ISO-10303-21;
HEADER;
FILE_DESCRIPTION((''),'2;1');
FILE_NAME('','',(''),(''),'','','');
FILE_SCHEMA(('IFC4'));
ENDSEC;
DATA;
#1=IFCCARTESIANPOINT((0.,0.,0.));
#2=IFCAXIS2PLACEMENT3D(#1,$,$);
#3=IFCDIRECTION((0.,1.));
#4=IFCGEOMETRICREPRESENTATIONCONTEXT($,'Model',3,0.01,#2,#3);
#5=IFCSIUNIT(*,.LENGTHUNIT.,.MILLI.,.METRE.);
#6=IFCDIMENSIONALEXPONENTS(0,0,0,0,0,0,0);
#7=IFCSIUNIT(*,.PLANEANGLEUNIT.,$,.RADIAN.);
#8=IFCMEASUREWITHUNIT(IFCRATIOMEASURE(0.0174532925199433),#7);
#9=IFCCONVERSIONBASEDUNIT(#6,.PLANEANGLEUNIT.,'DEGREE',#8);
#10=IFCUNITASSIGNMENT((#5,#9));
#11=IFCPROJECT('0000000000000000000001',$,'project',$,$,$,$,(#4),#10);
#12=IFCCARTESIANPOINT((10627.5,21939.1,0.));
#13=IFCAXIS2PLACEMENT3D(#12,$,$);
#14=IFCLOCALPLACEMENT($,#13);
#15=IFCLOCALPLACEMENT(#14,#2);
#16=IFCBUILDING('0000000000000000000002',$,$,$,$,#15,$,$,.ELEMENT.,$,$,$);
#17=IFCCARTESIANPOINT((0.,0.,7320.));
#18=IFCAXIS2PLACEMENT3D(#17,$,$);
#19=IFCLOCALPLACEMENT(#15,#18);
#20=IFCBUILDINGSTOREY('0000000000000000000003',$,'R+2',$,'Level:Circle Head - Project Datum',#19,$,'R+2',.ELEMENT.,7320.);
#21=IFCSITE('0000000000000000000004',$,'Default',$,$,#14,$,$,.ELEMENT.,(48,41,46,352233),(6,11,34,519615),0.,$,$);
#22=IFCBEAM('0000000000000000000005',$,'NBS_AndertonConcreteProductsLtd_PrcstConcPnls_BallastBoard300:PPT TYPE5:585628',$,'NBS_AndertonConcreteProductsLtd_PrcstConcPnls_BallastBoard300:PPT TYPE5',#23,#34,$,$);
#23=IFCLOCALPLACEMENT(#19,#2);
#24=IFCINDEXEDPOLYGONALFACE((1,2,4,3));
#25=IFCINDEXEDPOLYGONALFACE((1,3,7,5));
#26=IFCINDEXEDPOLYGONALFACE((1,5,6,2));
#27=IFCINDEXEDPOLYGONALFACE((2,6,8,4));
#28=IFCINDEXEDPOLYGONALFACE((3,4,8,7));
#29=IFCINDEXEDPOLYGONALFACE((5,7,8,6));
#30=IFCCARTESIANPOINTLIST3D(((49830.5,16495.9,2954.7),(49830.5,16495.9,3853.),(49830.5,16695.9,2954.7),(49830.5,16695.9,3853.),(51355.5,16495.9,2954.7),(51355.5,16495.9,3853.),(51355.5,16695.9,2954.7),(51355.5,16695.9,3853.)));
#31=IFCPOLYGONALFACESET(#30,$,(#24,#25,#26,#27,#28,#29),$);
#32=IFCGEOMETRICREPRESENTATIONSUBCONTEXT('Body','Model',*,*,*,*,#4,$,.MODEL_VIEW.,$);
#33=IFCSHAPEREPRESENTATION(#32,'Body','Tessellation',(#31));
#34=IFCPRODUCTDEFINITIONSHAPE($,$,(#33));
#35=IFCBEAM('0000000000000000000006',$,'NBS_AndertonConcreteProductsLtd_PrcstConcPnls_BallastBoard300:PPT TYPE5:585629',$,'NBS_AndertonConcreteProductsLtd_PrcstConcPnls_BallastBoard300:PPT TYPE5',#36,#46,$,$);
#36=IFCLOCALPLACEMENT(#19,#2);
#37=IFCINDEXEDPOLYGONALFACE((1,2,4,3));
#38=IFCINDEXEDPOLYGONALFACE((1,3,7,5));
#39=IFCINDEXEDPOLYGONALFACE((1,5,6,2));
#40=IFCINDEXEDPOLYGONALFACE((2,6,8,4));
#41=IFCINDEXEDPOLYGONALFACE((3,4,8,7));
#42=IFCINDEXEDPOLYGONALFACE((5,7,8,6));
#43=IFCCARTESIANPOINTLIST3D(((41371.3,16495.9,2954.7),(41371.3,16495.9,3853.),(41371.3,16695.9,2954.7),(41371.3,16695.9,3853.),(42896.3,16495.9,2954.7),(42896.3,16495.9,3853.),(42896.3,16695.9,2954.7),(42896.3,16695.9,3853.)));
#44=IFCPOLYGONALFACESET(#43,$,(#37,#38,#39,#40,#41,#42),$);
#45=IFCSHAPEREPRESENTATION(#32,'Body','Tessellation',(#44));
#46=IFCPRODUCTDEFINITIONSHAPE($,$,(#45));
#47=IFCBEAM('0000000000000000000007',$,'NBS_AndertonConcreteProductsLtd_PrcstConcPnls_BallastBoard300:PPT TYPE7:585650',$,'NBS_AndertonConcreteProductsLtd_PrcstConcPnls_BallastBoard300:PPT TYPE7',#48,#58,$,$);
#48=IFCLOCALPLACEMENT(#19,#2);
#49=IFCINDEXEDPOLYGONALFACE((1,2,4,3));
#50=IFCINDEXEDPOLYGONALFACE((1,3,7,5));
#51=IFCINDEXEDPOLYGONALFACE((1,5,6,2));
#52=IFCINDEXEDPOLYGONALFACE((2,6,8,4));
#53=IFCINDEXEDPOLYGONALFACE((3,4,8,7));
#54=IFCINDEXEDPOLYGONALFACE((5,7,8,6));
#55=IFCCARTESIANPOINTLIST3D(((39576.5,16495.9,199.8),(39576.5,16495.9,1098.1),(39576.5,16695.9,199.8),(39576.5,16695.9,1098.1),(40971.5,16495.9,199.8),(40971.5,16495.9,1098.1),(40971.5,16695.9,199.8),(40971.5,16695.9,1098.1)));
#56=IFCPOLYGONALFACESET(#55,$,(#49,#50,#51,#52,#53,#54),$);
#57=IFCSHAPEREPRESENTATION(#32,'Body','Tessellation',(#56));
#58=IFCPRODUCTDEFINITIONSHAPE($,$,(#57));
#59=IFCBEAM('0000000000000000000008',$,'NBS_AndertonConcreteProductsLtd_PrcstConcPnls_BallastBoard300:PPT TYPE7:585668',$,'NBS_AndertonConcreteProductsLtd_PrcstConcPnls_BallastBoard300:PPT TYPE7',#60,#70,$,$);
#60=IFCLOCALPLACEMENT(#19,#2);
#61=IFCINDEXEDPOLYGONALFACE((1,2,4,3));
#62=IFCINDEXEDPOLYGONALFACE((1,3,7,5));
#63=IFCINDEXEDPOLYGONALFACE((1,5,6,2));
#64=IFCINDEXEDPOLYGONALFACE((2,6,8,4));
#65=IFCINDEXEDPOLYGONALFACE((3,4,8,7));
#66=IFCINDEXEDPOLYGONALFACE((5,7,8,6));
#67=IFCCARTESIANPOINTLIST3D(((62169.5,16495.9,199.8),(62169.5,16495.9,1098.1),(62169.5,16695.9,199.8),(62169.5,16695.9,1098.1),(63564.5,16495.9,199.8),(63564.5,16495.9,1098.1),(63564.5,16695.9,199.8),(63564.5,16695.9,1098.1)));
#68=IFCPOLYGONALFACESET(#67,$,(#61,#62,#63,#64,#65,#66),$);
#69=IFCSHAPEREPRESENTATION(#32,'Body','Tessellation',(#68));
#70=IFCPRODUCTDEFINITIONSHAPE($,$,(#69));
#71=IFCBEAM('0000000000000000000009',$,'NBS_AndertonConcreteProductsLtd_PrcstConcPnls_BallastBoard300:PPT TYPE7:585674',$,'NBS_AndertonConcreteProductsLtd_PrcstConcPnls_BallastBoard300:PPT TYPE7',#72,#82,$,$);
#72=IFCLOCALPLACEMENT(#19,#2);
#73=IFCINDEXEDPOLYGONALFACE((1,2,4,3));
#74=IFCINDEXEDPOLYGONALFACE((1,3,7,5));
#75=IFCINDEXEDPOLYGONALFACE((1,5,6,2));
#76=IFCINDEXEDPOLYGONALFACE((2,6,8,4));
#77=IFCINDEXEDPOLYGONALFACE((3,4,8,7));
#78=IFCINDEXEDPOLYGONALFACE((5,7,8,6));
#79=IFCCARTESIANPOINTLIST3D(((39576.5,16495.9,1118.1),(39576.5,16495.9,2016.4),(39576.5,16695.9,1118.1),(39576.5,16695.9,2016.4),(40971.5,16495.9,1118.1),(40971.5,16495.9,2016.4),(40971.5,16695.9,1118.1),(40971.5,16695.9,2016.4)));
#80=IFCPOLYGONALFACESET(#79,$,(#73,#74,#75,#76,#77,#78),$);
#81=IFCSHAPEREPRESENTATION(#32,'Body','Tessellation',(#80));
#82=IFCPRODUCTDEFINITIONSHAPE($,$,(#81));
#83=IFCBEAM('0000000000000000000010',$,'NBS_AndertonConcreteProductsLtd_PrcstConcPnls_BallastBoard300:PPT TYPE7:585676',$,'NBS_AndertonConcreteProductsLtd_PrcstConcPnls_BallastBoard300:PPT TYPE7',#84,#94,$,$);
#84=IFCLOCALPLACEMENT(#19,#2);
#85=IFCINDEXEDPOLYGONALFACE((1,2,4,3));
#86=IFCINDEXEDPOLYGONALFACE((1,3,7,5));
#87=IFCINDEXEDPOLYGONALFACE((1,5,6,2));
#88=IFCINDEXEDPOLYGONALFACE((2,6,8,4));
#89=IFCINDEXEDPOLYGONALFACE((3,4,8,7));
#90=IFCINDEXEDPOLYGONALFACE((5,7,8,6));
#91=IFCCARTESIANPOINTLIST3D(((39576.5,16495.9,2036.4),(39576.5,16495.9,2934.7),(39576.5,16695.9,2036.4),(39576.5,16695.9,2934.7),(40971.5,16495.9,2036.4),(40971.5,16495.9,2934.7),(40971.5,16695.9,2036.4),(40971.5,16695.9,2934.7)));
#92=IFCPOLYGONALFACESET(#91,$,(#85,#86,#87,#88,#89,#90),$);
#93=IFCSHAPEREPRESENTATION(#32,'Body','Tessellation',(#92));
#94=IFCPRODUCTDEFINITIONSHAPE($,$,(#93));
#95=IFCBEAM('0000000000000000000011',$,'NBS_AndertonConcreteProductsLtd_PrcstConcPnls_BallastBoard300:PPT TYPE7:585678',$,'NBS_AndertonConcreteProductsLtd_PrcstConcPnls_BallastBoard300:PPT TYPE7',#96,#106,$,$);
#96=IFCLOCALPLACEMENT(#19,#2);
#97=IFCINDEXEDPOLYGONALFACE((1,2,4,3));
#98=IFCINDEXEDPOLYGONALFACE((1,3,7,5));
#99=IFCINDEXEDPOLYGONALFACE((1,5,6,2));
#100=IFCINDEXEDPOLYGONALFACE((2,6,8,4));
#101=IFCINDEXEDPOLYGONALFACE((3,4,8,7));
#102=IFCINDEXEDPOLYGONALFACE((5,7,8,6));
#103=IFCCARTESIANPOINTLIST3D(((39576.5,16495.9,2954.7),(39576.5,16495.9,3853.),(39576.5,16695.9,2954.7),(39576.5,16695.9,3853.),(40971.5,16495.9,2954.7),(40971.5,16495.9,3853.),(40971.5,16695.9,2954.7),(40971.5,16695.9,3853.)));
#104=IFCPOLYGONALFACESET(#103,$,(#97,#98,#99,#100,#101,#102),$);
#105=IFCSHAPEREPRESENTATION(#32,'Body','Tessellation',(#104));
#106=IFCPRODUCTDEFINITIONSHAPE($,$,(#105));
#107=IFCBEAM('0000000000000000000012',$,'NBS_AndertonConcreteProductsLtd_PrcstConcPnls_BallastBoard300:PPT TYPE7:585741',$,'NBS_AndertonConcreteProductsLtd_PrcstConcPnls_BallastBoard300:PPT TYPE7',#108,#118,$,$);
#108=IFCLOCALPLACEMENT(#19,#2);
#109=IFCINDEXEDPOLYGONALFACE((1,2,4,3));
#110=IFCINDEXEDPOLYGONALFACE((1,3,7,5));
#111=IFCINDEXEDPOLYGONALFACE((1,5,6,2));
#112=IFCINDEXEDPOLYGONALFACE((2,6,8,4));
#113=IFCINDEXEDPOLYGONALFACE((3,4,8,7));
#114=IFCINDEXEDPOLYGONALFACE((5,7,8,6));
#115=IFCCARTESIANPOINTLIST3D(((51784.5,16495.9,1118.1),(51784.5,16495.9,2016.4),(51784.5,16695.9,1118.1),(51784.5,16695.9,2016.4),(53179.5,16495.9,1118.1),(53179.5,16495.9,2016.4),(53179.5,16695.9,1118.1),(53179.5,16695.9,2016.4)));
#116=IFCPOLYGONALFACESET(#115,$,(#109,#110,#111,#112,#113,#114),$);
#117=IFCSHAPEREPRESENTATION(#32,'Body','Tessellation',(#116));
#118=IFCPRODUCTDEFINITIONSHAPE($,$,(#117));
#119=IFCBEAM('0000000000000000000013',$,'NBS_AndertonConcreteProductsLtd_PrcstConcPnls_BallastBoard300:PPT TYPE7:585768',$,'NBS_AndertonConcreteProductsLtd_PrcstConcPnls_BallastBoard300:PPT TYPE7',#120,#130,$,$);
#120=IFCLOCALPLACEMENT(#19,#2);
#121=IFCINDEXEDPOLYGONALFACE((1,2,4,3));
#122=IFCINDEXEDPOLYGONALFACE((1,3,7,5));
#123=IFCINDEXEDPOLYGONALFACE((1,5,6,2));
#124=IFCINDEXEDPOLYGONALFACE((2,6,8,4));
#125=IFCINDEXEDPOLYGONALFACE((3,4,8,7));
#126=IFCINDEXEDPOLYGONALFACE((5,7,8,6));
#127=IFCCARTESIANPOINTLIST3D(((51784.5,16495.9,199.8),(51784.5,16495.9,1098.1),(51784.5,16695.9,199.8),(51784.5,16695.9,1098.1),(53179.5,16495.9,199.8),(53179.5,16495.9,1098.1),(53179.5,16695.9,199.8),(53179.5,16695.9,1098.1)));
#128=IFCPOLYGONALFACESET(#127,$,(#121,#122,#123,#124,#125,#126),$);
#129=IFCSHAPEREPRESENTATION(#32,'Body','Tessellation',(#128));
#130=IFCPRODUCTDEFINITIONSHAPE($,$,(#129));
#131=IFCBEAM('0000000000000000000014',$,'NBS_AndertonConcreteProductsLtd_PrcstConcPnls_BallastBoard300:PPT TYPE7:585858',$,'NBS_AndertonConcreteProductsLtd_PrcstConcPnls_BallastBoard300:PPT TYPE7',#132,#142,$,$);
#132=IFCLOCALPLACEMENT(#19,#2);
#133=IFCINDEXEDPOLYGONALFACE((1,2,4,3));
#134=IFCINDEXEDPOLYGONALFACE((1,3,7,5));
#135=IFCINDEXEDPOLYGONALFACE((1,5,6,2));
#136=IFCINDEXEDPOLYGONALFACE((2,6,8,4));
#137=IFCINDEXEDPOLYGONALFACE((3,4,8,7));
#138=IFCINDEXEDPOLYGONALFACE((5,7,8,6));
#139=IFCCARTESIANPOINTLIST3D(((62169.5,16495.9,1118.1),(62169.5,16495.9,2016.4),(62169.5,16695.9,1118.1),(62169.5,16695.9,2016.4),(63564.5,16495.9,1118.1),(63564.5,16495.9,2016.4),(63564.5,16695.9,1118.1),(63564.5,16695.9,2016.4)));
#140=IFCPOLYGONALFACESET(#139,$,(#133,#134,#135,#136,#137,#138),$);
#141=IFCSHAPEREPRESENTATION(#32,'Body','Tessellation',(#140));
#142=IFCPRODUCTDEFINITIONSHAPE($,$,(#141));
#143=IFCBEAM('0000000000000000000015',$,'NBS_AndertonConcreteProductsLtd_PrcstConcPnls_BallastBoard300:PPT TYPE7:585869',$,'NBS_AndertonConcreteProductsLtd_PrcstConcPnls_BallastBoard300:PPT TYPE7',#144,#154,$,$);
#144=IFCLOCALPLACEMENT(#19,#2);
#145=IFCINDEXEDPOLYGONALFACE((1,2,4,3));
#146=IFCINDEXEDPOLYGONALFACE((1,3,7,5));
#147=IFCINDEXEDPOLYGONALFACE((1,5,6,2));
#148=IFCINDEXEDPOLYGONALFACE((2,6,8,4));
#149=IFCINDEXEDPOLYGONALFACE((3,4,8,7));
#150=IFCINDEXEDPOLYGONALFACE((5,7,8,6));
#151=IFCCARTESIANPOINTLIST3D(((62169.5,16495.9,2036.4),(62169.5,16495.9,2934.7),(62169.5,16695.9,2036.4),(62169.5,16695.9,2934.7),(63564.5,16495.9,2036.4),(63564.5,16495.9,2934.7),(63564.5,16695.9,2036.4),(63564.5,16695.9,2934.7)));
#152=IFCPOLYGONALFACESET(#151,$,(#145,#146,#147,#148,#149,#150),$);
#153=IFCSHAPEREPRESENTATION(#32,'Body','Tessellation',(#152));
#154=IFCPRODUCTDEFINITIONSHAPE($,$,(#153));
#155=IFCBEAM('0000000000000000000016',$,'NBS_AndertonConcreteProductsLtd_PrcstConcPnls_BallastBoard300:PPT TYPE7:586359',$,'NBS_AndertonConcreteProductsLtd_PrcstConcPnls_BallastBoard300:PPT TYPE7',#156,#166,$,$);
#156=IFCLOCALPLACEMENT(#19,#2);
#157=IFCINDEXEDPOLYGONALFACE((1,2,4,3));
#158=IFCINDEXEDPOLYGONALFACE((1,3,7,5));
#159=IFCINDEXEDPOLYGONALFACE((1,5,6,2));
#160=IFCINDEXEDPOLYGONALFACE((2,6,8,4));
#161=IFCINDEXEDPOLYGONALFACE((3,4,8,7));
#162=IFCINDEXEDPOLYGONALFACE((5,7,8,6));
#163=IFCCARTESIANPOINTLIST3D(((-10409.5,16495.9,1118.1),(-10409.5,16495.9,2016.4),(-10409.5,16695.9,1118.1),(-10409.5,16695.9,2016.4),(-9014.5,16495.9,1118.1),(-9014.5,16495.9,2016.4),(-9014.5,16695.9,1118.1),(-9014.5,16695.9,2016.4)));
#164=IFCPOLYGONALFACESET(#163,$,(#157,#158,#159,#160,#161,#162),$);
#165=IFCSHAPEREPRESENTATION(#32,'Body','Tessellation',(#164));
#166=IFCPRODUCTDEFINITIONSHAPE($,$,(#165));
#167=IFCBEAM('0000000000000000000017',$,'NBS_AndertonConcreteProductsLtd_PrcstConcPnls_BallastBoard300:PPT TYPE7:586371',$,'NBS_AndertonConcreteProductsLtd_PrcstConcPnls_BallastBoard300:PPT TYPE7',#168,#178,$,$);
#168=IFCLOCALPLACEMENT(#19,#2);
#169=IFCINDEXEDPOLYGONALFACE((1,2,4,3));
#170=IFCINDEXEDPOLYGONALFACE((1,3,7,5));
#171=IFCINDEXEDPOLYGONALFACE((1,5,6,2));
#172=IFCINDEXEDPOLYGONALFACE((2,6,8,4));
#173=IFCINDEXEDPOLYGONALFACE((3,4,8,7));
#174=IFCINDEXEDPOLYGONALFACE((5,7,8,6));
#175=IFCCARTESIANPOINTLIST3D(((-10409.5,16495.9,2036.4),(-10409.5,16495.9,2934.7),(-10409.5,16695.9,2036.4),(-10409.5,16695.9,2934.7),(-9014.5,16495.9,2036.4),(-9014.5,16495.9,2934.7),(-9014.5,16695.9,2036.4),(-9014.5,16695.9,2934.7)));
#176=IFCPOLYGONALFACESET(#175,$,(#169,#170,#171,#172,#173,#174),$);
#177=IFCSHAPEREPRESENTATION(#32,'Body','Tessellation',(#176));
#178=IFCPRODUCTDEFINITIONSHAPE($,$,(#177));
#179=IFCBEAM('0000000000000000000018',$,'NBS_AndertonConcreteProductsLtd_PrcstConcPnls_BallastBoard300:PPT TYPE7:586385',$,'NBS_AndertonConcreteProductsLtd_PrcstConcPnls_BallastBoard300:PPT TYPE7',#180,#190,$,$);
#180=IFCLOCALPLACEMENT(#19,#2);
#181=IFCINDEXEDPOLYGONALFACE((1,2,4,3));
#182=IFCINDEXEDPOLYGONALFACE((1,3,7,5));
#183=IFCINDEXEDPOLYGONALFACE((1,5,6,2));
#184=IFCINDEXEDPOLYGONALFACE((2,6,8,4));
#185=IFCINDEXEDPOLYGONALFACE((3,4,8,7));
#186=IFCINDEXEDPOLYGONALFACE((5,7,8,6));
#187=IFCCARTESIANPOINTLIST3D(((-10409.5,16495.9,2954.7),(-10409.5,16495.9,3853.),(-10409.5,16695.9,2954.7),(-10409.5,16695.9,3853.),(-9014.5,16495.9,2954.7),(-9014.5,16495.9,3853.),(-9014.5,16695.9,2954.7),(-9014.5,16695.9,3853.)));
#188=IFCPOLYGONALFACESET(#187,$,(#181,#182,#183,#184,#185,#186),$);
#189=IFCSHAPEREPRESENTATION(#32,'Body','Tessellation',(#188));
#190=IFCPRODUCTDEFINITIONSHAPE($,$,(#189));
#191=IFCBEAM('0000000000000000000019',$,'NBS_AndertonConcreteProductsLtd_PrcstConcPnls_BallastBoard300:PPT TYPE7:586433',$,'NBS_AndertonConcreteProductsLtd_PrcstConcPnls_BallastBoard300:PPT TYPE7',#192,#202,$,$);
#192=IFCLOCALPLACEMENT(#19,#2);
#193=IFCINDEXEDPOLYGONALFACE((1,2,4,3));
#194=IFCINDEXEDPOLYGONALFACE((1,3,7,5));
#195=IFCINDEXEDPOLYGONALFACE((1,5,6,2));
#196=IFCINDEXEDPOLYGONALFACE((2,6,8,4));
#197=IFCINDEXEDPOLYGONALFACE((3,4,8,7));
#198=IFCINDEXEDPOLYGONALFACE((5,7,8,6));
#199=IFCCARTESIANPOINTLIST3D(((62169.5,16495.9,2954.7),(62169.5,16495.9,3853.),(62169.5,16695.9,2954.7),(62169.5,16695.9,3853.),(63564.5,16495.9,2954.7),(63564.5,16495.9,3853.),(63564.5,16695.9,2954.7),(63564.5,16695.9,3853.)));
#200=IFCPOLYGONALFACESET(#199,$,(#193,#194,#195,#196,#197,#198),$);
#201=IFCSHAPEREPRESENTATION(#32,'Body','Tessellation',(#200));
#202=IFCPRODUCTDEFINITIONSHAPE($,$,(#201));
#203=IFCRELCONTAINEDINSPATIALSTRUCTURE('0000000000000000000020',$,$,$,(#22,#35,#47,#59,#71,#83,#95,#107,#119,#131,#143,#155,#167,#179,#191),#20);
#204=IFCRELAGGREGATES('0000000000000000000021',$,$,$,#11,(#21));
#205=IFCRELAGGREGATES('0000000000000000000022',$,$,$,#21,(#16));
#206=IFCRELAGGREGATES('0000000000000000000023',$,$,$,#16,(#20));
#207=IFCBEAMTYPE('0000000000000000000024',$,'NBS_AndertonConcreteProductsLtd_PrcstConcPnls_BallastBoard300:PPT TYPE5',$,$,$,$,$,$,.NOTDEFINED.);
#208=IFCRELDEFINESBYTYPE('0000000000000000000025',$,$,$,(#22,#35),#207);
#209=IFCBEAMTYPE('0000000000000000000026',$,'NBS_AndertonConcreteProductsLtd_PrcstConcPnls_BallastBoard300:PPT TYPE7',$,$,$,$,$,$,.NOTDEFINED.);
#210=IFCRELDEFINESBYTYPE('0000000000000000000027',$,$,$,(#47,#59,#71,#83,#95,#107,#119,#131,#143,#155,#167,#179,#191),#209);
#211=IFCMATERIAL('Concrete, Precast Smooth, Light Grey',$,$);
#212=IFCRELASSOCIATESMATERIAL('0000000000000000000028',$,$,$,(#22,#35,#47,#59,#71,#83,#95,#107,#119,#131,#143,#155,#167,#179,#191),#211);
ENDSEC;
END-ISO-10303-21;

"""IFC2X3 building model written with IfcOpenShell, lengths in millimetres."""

from ifc_helpers import new_model, entity, si_unit, converted_unit, direction, frame, frame_2d, origin, place, context, subcontext, project, spatial, rectangle, extrude, material, type_object, element, save


model = new_model("IFC2X3")

# Units and contexts
model_context = context("Model", 3, precision=0.01, world=origin(), true_north=direction((0.0, 1.0)))
body_context = subcontext(model_context, "Body", "Model", "MODEL_VIEW")
ifc_project = project(units=[si_unit("LENGTHUNIT", "METRE", prefix="MILLI"), converted_unit("PLANEANGLEUNIT", "DEGREE", entity("IfcRatioMeasure", 0.0174532925199433), si_unit("PLANEANGLEUNIT", "RADIAN"), dimensions=[0, 0, 0, 0, 0, 0, 0])], contexts=[model_context])

# Site, building, storey
site_placement = place(None, frame((10627.5, 21939.1, 0.0)))
site = spatial("IfcSite", under=ifc_project, at=site_placement, Name="Default", CompositionType="ELEMENT", RefLatitude=(48, 41, 46, 352233), RefLongitude=(6, 11, 34, 519615), RefElevation=0.0)
building_placement = place(site_placement, origin())
building = spatial("IfcBuilding", under=site, at=building_placement, CompositionType="ELEMENT")
storey_placement = place(building_placement, frame((0.0, 0.0, 7320.0)))
storey = spatial("IfcBuildingStorey", under=building, at=storey_placement, Name="R+2", ObjectType="Level:Circle Head - Project Datum", LongName="R+2", CompositionType="ELEMENT", Elevation=7320.0)

# Beams
ifc_material_1 = material(Name="Concrete, Precast Smooth, Light Grey")
beam_type_1 = type_object("IfcBeamType", Name="NBS_AndertonConcreteProductsLtd_PrcstConcPnls_BallastBoard300:PPT TYPE5", PredefinedType="NOTDEFINED")
beam_1_placement = place(storey_placement, origin())
element("IfcBeam", 1, at=beam_1_placement, inside=storey, type_object=beam_type_1, material=ifc_material_1, Name="NBS_AndertonConcreteProductsLtd_PrcstConcPnls_BallastBoard300:PPT TYPE5:585628", ObjectType="NBS_AndertonConcreteProductsLtd_PrcstConcPnls_BallastBoard300:PPT TYPE5", context=body_context, shape_type="SweptSolid", body=[
    extrude(rectangle(XDim=898.3, YDim=200.0, at=frame_2d((0.0, 0.0), x_axis=(1.0, 0.0))), frame((49830.5, 16595.9, 3403.9), z_axis=(1.0, 0.0, 0.0), x_axis=(0.0, 0.0, -1.0)), (0.0, 0.0, 1.0), 1525.0),
])
beam_2_placement = place(storey_placement, origin())
element("IfcBeam", 2, at=beam_2_placement, inside=storey, type_object=beam_type_1, material=ifc_material_1, Name="NBS_AndertonConcreteProductsLtd_PrcstConcPnls_BallastBoard300:PPT TYPE5:585629", ObjectType="NBS_AndertonConcreteProductsLtd_PrcstConcPnls_BallastBoard300:PPT TYPE5", context=body_context, shape_type="SweptSolid", body=[
    extrude(rectangle(XDim=898.3, YDim=200.0, at=frame_2d((0.0, 0.0), x_axis=(1.0, 0.0))), frame((41371.3, 16595.9, 3403.9), z_axis=(1.0, 0.0, 0.0), x_axis=(0.0, 0.0, -1.0)), (0.0, 0.0, 1.0), 1525.0),
])
beam_type_2 = type_object("IfcBeamType", Name="NBS_AndertonConcreteProductsLtd_PrcstConcPnls_BallastBoard300:PPT TYPE7", PredefinedType="NOTDEFINED")
beam_3_placement = place(storey_placement, origin())
element("IfcBeam", 3, at=beam_3_placement, inside=storey, type_object=beam_type_2, material=ifc_material_1, Name="NBS_AndertonConcreteProductsLtd_PrcstConcPnls_BallastBoard300:PPT TYPE7:585650", ObjectType="NBS_AndertonConcreteProductsLtd_PrcstConcPnls_BallastBoard300:PPT TYPE7", context=body_context, shape_type="SweptSolid", body=[
    extrude(rectangle(XDim=898.3, YDim=200.0, at=frame_2d((0.0, 0.0), x_axis=(1.0, 0.0))), frame((39576.5, 16595.9, 649.0), z_axis=(1.0, 0.0, 0.0), x_axis=(0.0, 0.0, -1.0)), (0.0, 0.0, 1.0), 1395.0),
])
beam_4_placement = place(storey_placement, origin())
element("IfcBeam", 4, at=beam_4_placement, inside=storey, type_object=beam_type_2, material=ifc_material_1, Name="NBS_AndertonConcreteProductsLtd_PrcstConcPnls_BallastBoard300:PPT TYPE7:585668", ObjectType="NBS_AndertonConcreteProductsLtd_PrcstConcPnls_BallastBoard300:PPT TYPE7", context=body_context, shape_type="SweptSolid", body=[
    extrude(rectangle(XDim=898.3, YDim=200.0, at=frame_2d((0.0, 0.0), x_axis=(1.0, 0.0))), frame((62169.5, 16595.9, 649.0), z_axis=(1.0, 0.0, 0.0), x_axis=(0.0, 0.0, -1.0)), (0.0, 0.0, 1.0), 1395.0),
])
beam_5_placement = place(storey_placement, origin())
element("IfcBeam", 5, at=beam_5_placement, inside=storey, type_object=beam_type_2, material=ifc_material_1, Name="NBS_AndertonConcreteProductsLtd_PrcstConcPnls_BallastBoard300:PPT TYPE7:585674", ObjectType="NBS_AndertonConcreteProductsLtd_PrcstConcPnls_BallastBoard300:PPT TYPE7", context=body_context, shape_type="SweptSolid", body=[
    extrude(rectangle(XDim=898.3, YDim=200.0, at=frame_2d((0.0, 0.0), x_axis=(1.0, 0.0))), frame((39576.5, 16595.9, 1567.3), z_axis=(1.0, 0.0, 0.0), x_axis=(0.0, 0.0, -1.0)), (0.0, 0.0, 1.0), 1395.0),
])
beam_6_placement = place(storey_placement, origin())
element("IfcBeam", 6, at=beam_6_placement, inside=storey, type_object=beam_type_2, material=ifc_material_1, Name="NBS_AndertonConcreteProductsLtd_PrcstConcPnls_BallastBoard300:PPT TYPE7:585676", ObjectType="NBS_AndertonConcreteProductsLtd_PrcstConcPnls_BallastBoard300:PPT TYPE7", context=body_context, shape_type="SweptSolid", body=[
    extrude(rectangle(XDim=898.3, YDim=200.0, at=frame_2d((0.0, 0.0), x_axis=(1.0, 0.0))), frame((39576.5, 16595.9, 2485.6), z_axis=(1.0, 0.0, 0.0), x_axis=(0.0, 0.0, -1.0)), (0.0, 0.0, 1.0), 1395.0),
])
beam_7_placement = place(storey_placement, origin())
element("IfcBeam", 7, at=beam_7_placement, inside=storey, type_object=beam_type_2, material=ifc_material_1, Name="NBS_AndertonConcreteProductsLtd_PrcstConcPnls_BallastBoard300:PPT TYPE7:585678", ObjectType="NBS_AndertonConcreteProductsLtd_PrcstConcPnls_BallastBoard300:PPT TYPE7", context=body_context, shape_type="SweptSolid", body=[
    extrude(rectangle(XDim=898.3, YDim=200.0, at=frame_2d((0.0, 0.0), x_axis=(1.0, 0.0))), frame((39576.5, 16595.9, 3403.9), z_axis=(1.0, 0.0, 0.0), x_axis=(0.0, 0.0, -1.0)), (0.0, 0.0, 1.0), 1395.0),
])
beam_8_placement = place(storey_placement, origin())
element("IfcBeam", 8, at=beam_8_placement, inside=storey, type_object=beam_type_2, material=ifc_material_1, Name="NBS_AndertonConcreteProductsLtd_PrcstConcPnls_BallastBoard300:PPT TYPE7:585741", ObjectType="NBS_AndertonConcreteProductsLtd_PrcstConcPnls_BallastBoard300:PPT TYPE7", context=body_context, shape_type="SweptSolid", body=[
    extrude(rectangle(XDim=898.3, YDim=200.0, at=frame_2d((0.0, 0.0), x_axis=(1.0, 0.0))), frame((51784.5, 16595.9, 1567.3), z_axis=(1.0, 0.0, 0.0), x_axis=(0.0, 0.0, -1.0)), (0.0, 0.0, 1.0), 1395.0),
])
beam_9_placement = place(storey_placement, origin())
element("IfcBeam", 9, at=beam_9_placement, inside=storey, type_object=beam_type_2, material=ifc_material_1, Name="NBS_AndertonConcreteProductsLtd_PrcstConcPnls_BallastBoard300:PPT TYPE7:585768", ObjectType="NBS_AndertonConcreteProductsLtd_PrcstConcPnls_BallastBoard300:PPT TYPE7", context=body_context, shape_type="SweptSolid", body=[
    extrude(rectangle(XDim=898.3, YDim=200.0, at=frame_2d((0.0, 0.0), x_axis=(1.0, 0.0))), frame((51784.5, 16595.9, 649.0), z_axis=(1.0, 0.0, 0.0), x_axis=(0.0, 0.0, -1.0)), (0.0, 0.0, 1.0), 1395.0),
])
beam_10_placement = place(storey_placement, origin())
element("IfcBeam", 10, at=beam_10_placement, inside=storey, type_object=beam_type_2, material=ifc_material_1, Name="NBS_AndertonConcreteProductsLtd_PrcstConcPnls_BallastBoard300:PPT TYPE7:585858", ObjectType="NBS_AndertonConcreteProductsLtd_PrcstConcPnls_BallastBoard300:PPT TYPE7", context=body_context, shape_type="SweptSolid", body=[
    extrude(rectangle(XDim=898.3, YDim=200.0, at=frame_2d((0.0, 0.0), x_axis=(1.0, 0.0))), frame((62169.5, 16595.9, 1567.3), z_axis=(1.0, 0.0, 0.0), x_axis=(0.0, 0.0, -1.0)), (0.0, 0.0, 1.0), 1395.0),
])
beam_11_placement = place(storey_placement, origin())
element("IfcBeam", 11, at=beam_11_placement, inside=storey, type_object=beam_type_2, material=ifc_material_1, Name="NBS_AndertonConcreteProductsLtd_PrcstConcPnls_BallastBoard300:PPT TYPE7:585869", ObjectType="NBS_AndertonConcreteProductsLtd_PrcstConcPnls_BallastBoard300:PPT TYPE7", context=body_context, shape_type="SweptSolid", body=[
    extrude(rectangle(XDim=898.3, YDim=200.0, at=frame_2d((0.0, 0.0), x_axis=(1.0, 0.0))), frame((62169.5, 16595.9, 2485.6), z_axis=(1.0, 0.0, 0.0), x_axis=(0.0, 0.0, -1.0)), (0.0, 0.0, 1.0), 1395.0),
])
beam_12_placement = place(storey_placement, origin())
element("IfcBeam", 12, at=beam_12_placement, inside=storey, type_object=beam_type_2, material=ifc_material_1, Name="NBS_AndertonConcreteProductsLtd_PrcstConcPnls_BallastBoard300:PPT TYPE7:586359", ObjectType="NBS_AndertonConcreteProductsLtd_PrcstConcPnls_BallastBoard300:PPT TYPE7", context=body_context, shape_type="SweptSolid", body=[
    extrude(rectangle(XDim=898.3, YDim=200.0, at=frame_2d((0.0, 0.0), x_axis=(0.0, 1.0))), frame((-10409.5, 16595.9, 1567.3), z_axis=(1.0, 0.0, 0.0), x_axis=(0.0, 1.0, 0.0)), (0.0, 0.0, 1.0), 1395.0),
])
beam_13_placement = place(storey_placement, origin())
element("IfcBeam", 13, at=beam_13_placement, inside=storey, type_object=beam_type_2, material=ifc_material_1, Name="NBS_AndertonConcreteProductsLtd_PrcstConcPnls_BallastBoard300:PPT TYPE7:586371", ObjectType="NBS_AndertonConcreteProductsLtd_PrcstConcPnls_BallastBoard300:PPT TYPE7", context=body_context, shape_type="SweptSolid", body=[
    extrude(rectangle(XDim=898.3, YDim=200.0, at=frame_2d((0.0, 0.0), x_axis=(0.0, 1.0))), frame((-10409.5, 16595.9, 2485.6), z_axis=(1.0, 0.0, 0.0), x_axis=(0.0, 1.0, 0.0)), (0.0, 0.0, 1.0), 1395.0),
])
beam_14_placement = place(storey_placement, origin())
element("IfcBeam", 14, at=beam_14_placement, inside=storey, type_object=beam_type_2, material=ifc_material_1, Name="NBS_AndertonConcreteProductsLtd_PrcstConcPnls_BallastBoard300:PPT TYPE7:586385", ObjectType="NBS_AndertonConcreteProductsLtd_PrcstConcPnls_BallastBoard300:PPT TYPE7", context=body_context, shape_type="SweptSolid", body=[
    extrude(rectangle(XDim=898.3, YDim=200.0, at=frame_2d((0.0, 0.0), x_axis=(0.0, 1.0))), frame((-10409.5, 16595.9, 3403.9), z_axis=(1.0, 0.0, 0.0), x_axis=(0.0, 1.0, 0.0)), (0.0, 0.0, 1.0), 1395.0),
])
beam_15_placement = place(storey_placement, origin())
element("IfcBeam", 15, at=beam_15_placement, inside=storey, type_object=beam_type_2, material=ifc_material_1, Name="NBS_AndertonConcreteProductsLtd_PrcstConcPnls_BallastBoard300:PPT TYPE7:586433", ObjectType="NBS_AndertonConcreteProductsLtd_PrcstConcPnls_BallastBoard300:PPT TYPE7", context=body_context, shape_type="SweptSolid", body=[
    extrude(rectangle(XDim=898.3, YDim=200.0, at=frame_2d((0.0, 0.0), x_axis=(1.0, 0.0))), frame((62169.5, 16595.9, 3403.9), z_axis=(1.0, 0.0, 0.0), x_axis=(0.0, 0.0, -1.0)), (0.0, 0.0, 1.0), 1395.0),
])

save(model, "model.ifc")
